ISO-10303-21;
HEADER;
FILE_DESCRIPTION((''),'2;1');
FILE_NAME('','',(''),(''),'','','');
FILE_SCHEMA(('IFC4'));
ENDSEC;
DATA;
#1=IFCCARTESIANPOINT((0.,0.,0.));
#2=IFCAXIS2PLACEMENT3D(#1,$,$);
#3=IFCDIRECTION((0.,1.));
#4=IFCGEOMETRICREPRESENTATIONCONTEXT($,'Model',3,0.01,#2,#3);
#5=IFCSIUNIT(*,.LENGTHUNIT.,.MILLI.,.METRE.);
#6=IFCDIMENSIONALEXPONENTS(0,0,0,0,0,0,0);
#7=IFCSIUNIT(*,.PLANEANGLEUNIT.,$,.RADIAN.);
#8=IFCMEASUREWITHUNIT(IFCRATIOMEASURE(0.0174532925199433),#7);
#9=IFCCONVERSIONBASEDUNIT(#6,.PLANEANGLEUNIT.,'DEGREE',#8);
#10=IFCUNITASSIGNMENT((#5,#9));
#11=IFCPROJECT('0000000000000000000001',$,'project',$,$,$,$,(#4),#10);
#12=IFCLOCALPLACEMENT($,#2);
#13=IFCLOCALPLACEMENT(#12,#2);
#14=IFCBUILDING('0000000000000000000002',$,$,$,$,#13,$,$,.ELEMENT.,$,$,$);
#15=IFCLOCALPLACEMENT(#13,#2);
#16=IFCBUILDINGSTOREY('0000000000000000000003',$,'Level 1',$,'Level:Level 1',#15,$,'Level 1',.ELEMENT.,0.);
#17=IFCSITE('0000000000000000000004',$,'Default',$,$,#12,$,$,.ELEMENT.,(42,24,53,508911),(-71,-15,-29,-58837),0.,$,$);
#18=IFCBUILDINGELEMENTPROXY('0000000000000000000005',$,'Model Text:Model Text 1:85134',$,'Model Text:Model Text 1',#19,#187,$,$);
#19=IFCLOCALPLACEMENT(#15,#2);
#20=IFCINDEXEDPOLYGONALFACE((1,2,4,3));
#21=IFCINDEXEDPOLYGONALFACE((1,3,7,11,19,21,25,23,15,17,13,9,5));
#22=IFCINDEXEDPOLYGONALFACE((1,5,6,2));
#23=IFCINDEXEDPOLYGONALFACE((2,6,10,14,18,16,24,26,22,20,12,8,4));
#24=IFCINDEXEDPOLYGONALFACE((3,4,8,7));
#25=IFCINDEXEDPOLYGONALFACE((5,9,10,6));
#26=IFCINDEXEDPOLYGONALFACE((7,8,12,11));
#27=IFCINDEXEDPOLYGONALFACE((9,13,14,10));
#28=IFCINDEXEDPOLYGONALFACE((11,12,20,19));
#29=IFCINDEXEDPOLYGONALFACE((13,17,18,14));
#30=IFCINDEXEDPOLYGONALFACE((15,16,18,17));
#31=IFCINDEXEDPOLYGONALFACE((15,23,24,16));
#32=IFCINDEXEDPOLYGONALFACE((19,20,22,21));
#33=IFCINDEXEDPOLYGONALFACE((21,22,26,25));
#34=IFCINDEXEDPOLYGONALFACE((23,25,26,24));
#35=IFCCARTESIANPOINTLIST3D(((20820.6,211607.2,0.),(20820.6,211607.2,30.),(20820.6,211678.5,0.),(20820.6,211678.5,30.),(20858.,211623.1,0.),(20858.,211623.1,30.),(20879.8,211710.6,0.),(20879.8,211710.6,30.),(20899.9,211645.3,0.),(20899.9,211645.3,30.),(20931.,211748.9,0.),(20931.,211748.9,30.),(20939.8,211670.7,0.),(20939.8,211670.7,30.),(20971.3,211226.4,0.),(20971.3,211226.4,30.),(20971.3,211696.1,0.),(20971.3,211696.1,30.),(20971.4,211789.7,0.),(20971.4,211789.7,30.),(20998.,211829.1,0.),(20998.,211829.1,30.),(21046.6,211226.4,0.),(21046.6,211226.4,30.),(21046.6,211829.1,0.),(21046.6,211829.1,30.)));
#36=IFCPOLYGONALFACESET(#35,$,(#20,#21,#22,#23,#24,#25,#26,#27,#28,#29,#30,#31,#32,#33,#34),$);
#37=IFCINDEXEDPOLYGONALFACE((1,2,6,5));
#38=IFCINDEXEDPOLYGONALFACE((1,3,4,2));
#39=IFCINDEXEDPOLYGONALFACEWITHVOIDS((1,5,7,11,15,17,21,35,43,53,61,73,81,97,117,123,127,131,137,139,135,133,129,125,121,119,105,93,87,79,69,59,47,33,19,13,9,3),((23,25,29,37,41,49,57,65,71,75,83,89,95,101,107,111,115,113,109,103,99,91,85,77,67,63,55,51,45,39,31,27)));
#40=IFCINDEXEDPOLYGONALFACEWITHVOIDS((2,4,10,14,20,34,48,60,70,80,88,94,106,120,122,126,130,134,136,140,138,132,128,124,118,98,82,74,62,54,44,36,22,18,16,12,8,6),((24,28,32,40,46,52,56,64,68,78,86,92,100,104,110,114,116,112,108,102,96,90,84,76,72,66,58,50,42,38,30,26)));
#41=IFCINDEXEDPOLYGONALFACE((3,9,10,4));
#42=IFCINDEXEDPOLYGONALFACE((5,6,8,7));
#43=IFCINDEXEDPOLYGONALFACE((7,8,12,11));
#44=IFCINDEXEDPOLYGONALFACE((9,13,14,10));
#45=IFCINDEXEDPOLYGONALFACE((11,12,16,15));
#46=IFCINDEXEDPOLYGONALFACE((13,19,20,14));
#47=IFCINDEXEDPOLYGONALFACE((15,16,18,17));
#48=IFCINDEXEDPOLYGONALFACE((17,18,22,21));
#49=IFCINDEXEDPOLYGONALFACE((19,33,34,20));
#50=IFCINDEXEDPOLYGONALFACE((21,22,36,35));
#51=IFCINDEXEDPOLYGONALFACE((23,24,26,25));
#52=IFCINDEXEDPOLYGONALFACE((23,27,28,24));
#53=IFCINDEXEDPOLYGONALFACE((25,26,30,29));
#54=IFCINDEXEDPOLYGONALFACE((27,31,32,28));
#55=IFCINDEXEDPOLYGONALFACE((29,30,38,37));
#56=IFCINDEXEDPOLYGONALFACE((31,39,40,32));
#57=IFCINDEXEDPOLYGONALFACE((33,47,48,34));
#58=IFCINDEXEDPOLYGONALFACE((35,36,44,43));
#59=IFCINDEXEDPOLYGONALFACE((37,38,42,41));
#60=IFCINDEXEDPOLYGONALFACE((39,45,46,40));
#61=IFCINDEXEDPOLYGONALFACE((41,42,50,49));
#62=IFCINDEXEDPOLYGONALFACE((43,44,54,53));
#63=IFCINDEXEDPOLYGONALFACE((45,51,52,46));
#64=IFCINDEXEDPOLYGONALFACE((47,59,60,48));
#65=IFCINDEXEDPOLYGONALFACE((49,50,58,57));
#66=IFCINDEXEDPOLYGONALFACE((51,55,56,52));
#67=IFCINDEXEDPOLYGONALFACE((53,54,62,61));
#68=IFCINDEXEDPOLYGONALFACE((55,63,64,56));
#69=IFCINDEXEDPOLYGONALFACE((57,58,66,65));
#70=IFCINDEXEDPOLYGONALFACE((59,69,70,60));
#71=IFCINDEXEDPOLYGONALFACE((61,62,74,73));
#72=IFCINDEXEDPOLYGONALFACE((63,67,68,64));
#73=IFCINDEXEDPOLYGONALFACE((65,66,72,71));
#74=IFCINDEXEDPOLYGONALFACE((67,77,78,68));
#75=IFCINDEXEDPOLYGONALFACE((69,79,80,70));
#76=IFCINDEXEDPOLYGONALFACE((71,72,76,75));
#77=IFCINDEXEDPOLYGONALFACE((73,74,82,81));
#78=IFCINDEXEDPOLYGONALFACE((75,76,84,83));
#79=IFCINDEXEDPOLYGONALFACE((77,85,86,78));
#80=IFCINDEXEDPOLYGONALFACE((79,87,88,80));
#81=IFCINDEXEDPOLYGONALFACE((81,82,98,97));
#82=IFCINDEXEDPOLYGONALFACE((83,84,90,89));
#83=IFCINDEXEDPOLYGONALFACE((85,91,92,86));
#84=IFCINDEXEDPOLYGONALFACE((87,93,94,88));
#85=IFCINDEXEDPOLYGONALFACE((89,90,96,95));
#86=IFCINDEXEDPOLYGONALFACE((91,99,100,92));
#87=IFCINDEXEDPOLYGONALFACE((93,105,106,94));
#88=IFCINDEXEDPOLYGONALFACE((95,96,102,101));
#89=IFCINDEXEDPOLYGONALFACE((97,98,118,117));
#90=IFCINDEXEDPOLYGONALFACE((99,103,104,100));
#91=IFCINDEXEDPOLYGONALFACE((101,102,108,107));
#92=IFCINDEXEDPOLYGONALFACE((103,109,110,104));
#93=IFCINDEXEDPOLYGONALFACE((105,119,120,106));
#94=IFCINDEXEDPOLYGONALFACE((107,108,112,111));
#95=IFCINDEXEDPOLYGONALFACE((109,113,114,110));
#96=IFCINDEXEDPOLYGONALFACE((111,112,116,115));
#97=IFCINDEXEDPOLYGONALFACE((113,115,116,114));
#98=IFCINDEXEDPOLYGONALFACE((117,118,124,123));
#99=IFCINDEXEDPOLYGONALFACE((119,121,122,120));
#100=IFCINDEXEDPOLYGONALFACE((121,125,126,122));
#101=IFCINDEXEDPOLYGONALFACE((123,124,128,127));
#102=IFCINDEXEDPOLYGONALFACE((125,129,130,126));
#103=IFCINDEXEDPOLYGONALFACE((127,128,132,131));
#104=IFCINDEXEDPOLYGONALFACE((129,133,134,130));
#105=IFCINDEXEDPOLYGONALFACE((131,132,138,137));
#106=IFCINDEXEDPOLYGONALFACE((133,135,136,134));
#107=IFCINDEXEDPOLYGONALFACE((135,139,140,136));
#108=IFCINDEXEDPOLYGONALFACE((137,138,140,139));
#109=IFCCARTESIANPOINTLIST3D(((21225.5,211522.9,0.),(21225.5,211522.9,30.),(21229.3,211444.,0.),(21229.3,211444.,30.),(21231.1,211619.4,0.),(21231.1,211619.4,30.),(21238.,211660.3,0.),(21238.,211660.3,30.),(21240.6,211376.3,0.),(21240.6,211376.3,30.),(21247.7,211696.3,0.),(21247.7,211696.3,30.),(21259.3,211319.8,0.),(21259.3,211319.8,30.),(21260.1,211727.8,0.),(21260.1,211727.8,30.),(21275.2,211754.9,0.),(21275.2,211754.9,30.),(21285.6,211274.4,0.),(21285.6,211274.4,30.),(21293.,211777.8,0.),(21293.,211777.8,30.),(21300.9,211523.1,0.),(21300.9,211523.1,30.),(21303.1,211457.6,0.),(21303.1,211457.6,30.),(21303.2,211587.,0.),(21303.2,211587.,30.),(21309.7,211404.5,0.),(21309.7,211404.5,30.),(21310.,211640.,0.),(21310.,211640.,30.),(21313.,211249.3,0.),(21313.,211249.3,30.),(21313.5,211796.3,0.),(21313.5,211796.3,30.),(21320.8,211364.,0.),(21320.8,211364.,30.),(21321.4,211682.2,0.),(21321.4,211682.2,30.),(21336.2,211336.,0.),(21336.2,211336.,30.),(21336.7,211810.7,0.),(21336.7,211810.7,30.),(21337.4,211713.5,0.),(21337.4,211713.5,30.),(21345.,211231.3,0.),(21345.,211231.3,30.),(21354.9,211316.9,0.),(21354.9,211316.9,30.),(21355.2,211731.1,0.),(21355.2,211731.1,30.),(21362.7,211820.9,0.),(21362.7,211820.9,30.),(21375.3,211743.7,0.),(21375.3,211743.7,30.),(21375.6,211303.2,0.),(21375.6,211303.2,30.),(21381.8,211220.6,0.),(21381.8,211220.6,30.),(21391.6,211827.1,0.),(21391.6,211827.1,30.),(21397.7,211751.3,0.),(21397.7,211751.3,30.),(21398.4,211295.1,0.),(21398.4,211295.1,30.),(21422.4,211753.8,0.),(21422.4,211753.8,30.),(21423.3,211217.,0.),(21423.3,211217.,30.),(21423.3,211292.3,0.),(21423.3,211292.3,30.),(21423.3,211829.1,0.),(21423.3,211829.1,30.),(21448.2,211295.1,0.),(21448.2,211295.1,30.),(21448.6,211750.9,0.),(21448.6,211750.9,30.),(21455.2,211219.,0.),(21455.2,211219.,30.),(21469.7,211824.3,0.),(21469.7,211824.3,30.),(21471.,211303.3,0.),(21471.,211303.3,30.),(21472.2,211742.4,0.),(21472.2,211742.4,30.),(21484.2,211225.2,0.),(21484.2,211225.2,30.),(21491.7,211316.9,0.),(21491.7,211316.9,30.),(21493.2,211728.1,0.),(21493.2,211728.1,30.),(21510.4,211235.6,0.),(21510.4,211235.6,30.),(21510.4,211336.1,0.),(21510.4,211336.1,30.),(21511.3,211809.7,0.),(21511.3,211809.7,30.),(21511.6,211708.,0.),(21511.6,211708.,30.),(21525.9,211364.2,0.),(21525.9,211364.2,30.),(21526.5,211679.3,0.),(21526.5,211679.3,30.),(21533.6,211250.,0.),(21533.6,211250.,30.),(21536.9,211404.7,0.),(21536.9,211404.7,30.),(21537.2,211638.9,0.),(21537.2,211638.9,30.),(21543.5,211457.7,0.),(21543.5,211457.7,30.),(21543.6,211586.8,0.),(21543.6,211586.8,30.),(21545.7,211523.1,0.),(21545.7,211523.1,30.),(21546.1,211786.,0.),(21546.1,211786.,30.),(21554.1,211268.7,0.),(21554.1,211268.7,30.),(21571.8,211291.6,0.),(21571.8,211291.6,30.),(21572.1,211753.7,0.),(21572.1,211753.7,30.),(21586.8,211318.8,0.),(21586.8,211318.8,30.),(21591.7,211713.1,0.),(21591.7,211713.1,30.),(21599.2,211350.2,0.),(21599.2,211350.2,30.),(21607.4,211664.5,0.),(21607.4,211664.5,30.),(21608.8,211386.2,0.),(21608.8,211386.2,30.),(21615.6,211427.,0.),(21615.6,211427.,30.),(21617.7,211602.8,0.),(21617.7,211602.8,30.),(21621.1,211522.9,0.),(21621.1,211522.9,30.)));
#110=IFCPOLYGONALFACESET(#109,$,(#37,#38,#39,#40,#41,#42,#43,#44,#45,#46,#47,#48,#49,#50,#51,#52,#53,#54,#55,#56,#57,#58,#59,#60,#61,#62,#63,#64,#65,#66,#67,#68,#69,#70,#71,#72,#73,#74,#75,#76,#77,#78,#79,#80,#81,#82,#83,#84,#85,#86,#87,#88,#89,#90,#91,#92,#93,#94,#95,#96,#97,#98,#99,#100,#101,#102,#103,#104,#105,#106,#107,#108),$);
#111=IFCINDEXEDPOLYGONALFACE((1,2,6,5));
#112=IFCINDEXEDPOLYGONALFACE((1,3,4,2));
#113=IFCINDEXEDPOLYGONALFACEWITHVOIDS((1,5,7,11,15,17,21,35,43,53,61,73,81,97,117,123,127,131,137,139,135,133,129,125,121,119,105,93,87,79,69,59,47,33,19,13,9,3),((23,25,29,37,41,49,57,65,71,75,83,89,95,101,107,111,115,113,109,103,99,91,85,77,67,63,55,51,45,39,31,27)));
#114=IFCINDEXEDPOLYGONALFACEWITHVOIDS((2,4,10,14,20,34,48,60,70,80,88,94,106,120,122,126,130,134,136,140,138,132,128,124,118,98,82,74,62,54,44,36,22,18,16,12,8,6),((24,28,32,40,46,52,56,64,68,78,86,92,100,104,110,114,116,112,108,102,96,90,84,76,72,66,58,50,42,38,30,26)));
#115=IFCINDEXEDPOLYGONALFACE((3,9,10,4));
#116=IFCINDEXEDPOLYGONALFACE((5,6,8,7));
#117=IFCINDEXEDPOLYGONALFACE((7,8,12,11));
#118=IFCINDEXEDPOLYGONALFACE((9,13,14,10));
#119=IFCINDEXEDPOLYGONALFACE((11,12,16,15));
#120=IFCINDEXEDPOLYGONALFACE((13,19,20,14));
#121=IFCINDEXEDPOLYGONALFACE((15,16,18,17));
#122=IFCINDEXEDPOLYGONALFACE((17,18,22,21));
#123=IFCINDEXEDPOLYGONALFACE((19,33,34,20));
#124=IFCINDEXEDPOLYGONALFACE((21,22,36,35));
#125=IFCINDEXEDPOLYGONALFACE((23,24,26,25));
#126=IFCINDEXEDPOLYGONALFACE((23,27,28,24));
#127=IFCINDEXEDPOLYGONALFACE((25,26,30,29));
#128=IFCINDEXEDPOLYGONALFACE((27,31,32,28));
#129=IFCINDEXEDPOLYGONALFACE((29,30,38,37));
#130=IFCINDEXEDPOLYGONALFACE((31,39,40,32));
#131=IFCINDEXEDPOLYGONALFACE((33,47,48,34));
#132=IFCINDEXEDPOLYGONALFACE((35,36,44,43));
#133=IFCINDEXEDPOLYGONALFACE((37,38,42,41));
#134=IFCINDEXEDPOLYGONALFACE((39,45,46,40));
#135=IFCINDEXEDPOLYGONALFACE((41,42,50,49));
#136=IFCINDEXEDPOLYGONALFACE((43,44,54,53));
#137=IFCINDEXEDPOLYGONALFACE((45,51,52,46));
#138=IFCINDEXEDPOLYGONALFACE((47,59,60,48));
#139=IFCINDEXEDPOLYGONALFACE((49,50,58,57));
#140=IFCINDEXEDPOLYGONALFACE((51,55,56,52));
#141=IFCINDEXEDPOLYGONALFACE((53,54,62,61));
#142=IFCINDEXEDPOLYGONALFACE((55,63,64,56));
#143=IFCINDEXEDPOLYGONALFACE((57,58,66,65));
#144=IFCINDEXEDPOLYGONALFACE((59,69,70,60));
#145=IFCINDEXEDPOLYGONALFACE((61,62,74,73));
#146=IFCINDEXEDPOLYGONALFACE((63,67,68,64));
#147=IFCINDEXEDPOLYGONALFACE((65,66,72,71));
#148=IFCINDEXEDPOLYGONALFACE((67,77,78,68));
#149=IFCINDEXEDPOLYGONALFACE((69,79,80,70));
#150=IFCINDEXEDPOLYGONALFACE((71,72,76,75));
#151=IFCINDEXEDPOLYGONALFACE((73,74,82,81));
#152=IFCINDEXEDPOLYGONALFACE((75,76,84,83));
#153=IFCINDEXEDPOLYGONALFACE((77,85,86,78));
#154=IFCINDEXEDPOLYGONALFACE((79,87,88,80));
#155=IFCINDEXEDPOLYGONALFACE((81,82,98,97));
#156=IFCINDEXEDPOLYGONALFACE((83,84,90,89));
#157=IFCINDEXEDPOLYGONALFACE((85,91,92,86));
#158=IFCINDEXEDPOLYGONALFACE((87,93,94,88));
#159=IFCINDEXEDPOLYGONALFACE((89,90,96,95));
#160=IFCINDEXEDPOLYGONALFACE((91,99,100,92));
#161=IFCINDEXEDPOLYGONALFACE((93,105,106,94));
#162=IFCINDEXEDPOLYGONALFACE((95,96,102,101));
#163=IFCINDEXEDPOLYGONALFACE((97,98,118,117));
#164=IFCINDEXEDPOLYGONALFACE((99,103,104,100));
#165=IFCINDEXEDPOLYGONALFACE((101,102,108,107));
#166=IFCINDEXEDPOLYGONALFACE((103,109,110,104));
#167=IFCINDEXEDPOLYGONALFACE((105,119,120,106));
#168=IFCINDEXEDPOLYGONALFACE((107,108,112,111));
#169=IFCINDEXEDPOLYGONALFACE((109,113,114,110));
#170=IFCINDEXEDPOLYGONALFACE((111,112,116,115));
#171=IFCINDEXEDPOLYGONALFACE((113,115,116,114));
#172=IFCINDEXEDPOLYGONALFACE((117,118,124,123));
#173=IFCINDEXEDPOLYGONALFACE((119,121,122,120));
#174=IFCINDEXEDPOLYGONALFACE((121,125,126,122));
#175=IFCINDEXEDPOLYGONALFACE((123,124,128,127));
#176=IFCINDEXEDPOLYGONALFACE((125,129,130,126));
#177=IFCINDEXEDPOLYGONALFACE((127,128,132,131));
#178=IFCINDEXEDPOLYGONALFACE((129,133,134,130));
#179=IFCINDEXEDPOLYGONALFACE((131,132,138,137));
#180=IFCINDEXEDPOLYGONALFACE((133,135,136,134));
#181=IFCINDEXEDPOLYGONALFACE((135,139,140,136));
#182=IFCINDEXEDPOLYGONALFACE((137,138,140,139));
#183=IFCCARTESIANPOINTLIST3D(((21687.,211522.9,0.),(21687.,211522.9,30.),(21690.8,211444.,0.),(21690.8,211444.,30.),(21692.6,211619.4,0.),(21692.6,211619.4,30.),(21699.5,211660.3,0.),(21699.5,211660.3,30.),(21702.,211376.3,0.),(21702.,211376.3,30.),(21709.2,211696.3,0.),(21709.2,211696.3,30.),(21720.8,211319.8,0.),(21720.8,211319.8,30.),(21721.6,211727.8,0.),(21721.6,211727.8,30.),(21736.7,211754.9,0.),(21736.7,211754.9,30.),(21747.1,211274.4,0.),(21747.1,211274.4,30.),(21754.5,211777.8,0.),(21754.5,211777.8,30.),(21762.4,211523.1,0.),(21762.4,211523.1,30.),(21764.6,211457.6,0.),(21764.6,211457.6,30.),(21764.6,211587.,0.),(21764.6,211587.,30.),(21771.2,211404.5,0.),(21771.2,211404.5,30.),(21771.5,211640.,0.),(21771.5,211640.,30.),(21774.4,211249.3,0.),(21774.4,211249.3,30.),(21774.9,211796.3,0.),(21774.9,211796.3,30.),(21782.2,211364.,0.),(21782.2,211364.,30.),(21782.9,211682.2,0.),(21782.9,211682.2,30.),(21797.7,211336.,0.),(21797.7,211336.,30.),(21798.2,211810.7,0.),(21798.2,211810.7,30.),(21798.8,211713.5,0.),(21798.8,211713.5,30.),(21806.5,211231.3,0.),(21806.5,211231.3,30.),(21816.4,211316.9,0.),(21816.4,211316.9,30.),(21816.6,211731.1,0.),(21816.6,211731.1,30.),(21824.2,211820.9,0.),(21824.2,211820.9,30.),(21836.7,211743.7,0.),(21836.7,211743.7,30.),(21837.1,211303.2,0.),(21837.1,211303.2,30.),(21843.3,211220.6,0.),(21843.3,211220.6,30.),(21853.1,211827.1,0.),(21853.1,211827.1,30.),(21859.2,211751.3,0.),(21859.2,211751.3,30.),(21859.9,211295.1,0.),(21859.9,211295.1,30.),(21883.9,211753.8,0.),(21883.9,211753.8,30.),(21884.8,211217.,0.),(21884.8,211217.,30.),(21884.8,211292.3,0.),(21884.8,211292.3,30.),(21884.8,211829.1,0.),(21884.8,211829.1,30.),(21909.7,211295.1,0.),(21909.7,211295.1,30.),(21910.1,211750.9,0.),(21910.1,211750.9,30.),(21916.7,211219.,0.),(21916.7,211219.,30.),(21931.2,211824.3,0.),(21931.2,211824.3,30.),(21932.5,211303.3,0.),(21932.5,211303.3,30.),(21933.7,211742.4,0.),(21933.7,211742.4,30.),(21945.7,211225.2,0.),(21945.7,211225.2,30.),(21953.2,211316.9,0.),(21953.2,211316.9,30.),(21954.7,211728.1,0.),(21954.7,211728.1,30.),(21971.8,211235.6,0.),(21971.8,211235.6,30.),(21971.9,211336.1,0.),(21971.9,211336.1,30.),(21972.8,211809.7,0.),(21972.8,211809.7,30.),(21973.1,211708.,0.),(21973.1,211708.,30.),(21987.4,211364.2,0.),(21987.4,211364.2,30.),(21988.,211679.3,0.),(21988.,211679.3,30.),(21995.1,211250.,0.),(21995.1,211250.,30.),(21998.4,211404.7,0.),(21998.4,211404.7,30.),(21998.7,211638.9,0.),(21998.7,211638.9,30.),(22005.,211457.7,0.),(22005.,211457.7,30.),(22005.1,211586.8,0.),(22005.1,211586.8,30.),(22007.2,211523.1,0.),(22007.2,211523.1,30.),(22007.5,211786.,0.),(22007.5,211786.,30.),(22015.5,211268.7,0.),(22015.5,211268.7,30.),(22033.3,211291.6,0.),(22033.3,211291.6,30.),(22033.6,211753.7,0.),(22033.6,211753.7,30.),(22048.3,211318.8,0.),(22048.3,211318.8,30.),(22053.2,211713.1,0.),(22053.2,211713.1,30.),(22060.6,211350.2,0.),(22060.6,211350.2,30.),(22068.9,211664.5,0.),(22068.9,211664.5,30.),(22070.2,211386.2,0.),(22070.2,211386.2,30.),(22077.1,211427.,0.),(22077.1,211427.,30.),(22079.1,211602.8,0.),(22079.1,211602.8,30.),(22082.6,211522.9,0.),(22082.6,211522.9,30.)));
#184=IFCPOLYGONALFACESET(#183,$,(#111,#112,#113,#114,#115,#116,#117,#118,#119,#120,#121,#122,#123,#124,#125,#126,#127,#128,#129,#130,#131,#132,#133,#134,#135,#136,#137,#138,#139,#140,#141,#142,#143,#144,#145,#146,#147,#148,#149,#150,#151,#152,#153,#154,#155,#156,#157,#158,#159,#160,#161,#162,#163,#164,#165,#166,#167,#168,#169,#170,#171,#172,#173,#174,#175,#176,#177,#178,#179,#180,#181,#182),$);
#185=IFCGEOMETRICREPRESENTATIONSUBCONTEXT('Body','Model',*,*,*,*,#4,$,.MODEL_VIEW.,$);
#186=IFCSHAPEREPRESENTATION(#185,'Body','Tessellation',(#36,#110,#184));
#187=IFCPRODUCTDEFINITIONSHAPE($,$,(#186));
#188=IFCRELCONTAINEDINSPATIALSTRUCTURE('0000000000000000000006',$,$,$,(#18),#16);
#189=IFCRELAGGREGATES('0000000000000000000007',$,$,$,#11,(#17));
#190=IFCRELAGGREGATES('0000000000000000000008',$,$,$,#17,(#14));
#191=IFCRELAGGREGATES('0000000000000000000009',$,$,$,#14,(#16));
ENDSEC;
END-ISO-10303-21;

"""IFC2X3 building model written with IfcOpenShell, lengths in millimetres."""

from ifc_helpers import new_model, entity, si_unit, converted_unit, direction, frame, origin, place, context, subcontext, project, spatial, polyline, outline, extrude, element, save


model = new_model("IFC2X3")

# Units and contexts
model_context = context("Model", 3, precision=0.01, world=origin(), true_north=direction((0.0, 1.0)))
body_context = subcontext(model_context, "Body", "Model", "MODEL_VIEW")
ifc_project = project(units=[si_unit("LENGTHUNIT", "METRE", prefix="MILLI"), converted_unit("PLANEANGLEUNIT", "DEGREE", entity("IfcRatioMeasure", 0.0174532925199433), si_unit("PLANEANGLEUNIT", "RADIAN"), dimensions=[0, 0, 0, 0, 0, 0, 0])], contexts=[model_context])

# Site, building, storey
site_placement = place(None, origin())
site = spatial("IfcSite", under=ifc_project, at=site_placement, Name="Default", CompositionType="ELEMENT", RefLatitude=(42, 24, 53, 508911), RefLongitude=(-71, -15, -29, -58837), RefElevation=0.0)
building_placement = place(site_placement, origin())
building = spatial("IfcBuilding", under=site, at=building_placement, CompositionType="ELEMENT")
storey_placement = place(building_placement, origin())
storey = spatial("IfcBuildingStorey", under=building, at=storey_placement, Name="Level 1", ObjectType="Level:Level 1", LongName="Level 1", CompositionType="ELEMENT", Elevation=0.0)

# Building element proxy
proxy_1_placement = place(storey_placement, origin())
element("IfcBuildingElementProxy", 1, at=proxy_1_placement, inside=storey, Name="Model Text:Model Text 1:85134", ObjectType="Model Text:Model Text 1", context=body_context, shape_type="SweptSolid", body=[
    extrude(outline(polyline([(-410.6, -111.6), (192.1, -111.6), (192.1, -63.1), (152.7, -36.4), (111.9, 4.0), (73.6, 55.2), (41.4, 114.4), (-29.8, 114.4), (-13.9, 77.0), (8.3, 35.1), (33.7, -4.8), (59.1, -36.3), (-410.6, -36.3), (-410.6, -111.6)])), frame((20935.0, 211637.0, 0.0), z_axis=(0.0, 0.0, 1.0), x_axis=(0.0, 1.0, 0.0)), (0.0, 0.0, 1.0), 30.0),
    extrude(outline(polyline([(-10.6, -198.7), (68.3, -198.7), (136.5, -190.7), (193.9, -174.7), (240.5, -150.6), (266.9, -124.4), (286.3, -93.2), (298.8, -57.0), (304.3, -15.7), (303.8, 16.2), (299.0, 45.5), (289.9, 72.1), (276.6, 96.0), (258.9, 117.3), (236.9, 136.2), (210.4, 152.5), (179.6, 166.3), (144.1, 177.6), (103.7, 186.3), (8.2, 196.4), (-71.8, 196.7), (-134.0, 189.4), (-183.3, 176.1), (-224.7, 158.4), (-258.2, 133.9), (-283.5, 100.3), (-300.1, 59.5), (-307.1, 13.4), (-306.6, -18.4), (-301.8, -47.5), (-292.8, -74.0), (-279.6, -97.9), (-262.0, -119.2), (-240.0, -138.1), (-213.6, -154.5), (-182.8, -168.4), (-147.3, -179.8), (-106.7, -188.6), (-10.6, -198.7)]), holes=[polyline([(-7.2, -123.5), (-71.0, -118.2), (-123.6, -108.8), (-165.2, -95.4), (-195.7, -78.0), (-212.4, -59.4), (-224.1, -38.7), (-230.6, -15.9), (-231.9, 8.9), (-227.8, 35.0), (-218.1, 58.1), (-202.8, 78.4), (-182.0, 95.8), (-152.6, 109.4), (-111.7, 118.1), (-59.4, 122.0), (4.4, 121.1), (69.6, 115.8), (122.2, 106.7), (162.2, 93.7), (189.5, 77.0), (207.7, 57.4), (220.4, 36.0), (227.5, 12.8), (229.1, -12.1), (225.2, -36.8), (215.9, -59.2), (201.3, -79.3), (181.4, -97.1), (152.6, -111.2), (111.6, -120.3), (58.3, -124.4), (-7.2, -123.5)])]), frame((21424.6, 211521.7, 0.0), z_axis=(0.0, 0.0, 1.0), x_axis=(0.047515, -0.998871, 0.0)), (0.0, 0.0, 1.0), 30.0),
    extrude(outline(polyline([(-10.6, -198.7), (68.3, -198.7), (136.5, -190.7), (193.9, -174.7), (240.5, -150.6), (266.9, -124.4), (286.3, -93.2), (298.8, -57.0), (304.3, -15.7), (303.8, 16.2), (299.0, 45.5), (289.9, 72.1), (276.6, 96.0), (258.9, 117.3), (236.9, 136.2), (210.4, 152.5), (179.6, 166.3), (144.1, 177.6), (103.7, 186.3), (8.2, 196.4), (-71.8, 196.7), (-134.0, 189.4), (-183.3, 176.1), (-224.7, 158.4), (-258.2, 133.9), (-283.5, 100.3), (-300.1, 59.5), (-307.1, 13.4), (-306.6, -18.4), (-301.8, -47.5), (-292.8, -74.0), (-279.6, -97.9), (-262.0, -119.2), (-240.0, -138.1), (-213.6, -154.5), (-182.8, -168.4), (-147.3, -179.8), (-106.7, -188.6), (-10.6, -198.7)]), holes=[polyline([(-7.2, -123.5), (-71.0, -118.2), (-123.6, -108.8), (-165.2, -95.4), (-195.7, -78.0), (-212.4, -59.4), (-224.1, -38.7), (-230.6, -15.9), (-231.9, 8.9), (-227.8, 35.0), (-218.1, 58.1), (-202.8, 78.4), (-182.0, 95.8), (-152.6, 109.4), (-111.7, 118.1), (-59.4, 122.0), (4.4, 121.1), (69.6, 115.8), (122.2, 106.7), (162.2, 93.7), (189.5, 77.0), (207.7, 57.4), (220.4, 36.0), (227.5, 12.8), (229.1, -12.1), (225.2, -36.8), (215.9, -59.2), (201.3, -79.3), (181.4, -97.1), (152.6, -111.2), (111.6, -120.3), (58.3, -124.4), (-7.2, -123.5)])]), frame((21886.0, 211521.7, 0.0), z_axis=(0.0, 0.0, 1.0), x_axis=(0.047515, -0.998871, 0.0)), (0.0, 0.0, 1.0), 30.0),
])

save(model, "model.ifc")
